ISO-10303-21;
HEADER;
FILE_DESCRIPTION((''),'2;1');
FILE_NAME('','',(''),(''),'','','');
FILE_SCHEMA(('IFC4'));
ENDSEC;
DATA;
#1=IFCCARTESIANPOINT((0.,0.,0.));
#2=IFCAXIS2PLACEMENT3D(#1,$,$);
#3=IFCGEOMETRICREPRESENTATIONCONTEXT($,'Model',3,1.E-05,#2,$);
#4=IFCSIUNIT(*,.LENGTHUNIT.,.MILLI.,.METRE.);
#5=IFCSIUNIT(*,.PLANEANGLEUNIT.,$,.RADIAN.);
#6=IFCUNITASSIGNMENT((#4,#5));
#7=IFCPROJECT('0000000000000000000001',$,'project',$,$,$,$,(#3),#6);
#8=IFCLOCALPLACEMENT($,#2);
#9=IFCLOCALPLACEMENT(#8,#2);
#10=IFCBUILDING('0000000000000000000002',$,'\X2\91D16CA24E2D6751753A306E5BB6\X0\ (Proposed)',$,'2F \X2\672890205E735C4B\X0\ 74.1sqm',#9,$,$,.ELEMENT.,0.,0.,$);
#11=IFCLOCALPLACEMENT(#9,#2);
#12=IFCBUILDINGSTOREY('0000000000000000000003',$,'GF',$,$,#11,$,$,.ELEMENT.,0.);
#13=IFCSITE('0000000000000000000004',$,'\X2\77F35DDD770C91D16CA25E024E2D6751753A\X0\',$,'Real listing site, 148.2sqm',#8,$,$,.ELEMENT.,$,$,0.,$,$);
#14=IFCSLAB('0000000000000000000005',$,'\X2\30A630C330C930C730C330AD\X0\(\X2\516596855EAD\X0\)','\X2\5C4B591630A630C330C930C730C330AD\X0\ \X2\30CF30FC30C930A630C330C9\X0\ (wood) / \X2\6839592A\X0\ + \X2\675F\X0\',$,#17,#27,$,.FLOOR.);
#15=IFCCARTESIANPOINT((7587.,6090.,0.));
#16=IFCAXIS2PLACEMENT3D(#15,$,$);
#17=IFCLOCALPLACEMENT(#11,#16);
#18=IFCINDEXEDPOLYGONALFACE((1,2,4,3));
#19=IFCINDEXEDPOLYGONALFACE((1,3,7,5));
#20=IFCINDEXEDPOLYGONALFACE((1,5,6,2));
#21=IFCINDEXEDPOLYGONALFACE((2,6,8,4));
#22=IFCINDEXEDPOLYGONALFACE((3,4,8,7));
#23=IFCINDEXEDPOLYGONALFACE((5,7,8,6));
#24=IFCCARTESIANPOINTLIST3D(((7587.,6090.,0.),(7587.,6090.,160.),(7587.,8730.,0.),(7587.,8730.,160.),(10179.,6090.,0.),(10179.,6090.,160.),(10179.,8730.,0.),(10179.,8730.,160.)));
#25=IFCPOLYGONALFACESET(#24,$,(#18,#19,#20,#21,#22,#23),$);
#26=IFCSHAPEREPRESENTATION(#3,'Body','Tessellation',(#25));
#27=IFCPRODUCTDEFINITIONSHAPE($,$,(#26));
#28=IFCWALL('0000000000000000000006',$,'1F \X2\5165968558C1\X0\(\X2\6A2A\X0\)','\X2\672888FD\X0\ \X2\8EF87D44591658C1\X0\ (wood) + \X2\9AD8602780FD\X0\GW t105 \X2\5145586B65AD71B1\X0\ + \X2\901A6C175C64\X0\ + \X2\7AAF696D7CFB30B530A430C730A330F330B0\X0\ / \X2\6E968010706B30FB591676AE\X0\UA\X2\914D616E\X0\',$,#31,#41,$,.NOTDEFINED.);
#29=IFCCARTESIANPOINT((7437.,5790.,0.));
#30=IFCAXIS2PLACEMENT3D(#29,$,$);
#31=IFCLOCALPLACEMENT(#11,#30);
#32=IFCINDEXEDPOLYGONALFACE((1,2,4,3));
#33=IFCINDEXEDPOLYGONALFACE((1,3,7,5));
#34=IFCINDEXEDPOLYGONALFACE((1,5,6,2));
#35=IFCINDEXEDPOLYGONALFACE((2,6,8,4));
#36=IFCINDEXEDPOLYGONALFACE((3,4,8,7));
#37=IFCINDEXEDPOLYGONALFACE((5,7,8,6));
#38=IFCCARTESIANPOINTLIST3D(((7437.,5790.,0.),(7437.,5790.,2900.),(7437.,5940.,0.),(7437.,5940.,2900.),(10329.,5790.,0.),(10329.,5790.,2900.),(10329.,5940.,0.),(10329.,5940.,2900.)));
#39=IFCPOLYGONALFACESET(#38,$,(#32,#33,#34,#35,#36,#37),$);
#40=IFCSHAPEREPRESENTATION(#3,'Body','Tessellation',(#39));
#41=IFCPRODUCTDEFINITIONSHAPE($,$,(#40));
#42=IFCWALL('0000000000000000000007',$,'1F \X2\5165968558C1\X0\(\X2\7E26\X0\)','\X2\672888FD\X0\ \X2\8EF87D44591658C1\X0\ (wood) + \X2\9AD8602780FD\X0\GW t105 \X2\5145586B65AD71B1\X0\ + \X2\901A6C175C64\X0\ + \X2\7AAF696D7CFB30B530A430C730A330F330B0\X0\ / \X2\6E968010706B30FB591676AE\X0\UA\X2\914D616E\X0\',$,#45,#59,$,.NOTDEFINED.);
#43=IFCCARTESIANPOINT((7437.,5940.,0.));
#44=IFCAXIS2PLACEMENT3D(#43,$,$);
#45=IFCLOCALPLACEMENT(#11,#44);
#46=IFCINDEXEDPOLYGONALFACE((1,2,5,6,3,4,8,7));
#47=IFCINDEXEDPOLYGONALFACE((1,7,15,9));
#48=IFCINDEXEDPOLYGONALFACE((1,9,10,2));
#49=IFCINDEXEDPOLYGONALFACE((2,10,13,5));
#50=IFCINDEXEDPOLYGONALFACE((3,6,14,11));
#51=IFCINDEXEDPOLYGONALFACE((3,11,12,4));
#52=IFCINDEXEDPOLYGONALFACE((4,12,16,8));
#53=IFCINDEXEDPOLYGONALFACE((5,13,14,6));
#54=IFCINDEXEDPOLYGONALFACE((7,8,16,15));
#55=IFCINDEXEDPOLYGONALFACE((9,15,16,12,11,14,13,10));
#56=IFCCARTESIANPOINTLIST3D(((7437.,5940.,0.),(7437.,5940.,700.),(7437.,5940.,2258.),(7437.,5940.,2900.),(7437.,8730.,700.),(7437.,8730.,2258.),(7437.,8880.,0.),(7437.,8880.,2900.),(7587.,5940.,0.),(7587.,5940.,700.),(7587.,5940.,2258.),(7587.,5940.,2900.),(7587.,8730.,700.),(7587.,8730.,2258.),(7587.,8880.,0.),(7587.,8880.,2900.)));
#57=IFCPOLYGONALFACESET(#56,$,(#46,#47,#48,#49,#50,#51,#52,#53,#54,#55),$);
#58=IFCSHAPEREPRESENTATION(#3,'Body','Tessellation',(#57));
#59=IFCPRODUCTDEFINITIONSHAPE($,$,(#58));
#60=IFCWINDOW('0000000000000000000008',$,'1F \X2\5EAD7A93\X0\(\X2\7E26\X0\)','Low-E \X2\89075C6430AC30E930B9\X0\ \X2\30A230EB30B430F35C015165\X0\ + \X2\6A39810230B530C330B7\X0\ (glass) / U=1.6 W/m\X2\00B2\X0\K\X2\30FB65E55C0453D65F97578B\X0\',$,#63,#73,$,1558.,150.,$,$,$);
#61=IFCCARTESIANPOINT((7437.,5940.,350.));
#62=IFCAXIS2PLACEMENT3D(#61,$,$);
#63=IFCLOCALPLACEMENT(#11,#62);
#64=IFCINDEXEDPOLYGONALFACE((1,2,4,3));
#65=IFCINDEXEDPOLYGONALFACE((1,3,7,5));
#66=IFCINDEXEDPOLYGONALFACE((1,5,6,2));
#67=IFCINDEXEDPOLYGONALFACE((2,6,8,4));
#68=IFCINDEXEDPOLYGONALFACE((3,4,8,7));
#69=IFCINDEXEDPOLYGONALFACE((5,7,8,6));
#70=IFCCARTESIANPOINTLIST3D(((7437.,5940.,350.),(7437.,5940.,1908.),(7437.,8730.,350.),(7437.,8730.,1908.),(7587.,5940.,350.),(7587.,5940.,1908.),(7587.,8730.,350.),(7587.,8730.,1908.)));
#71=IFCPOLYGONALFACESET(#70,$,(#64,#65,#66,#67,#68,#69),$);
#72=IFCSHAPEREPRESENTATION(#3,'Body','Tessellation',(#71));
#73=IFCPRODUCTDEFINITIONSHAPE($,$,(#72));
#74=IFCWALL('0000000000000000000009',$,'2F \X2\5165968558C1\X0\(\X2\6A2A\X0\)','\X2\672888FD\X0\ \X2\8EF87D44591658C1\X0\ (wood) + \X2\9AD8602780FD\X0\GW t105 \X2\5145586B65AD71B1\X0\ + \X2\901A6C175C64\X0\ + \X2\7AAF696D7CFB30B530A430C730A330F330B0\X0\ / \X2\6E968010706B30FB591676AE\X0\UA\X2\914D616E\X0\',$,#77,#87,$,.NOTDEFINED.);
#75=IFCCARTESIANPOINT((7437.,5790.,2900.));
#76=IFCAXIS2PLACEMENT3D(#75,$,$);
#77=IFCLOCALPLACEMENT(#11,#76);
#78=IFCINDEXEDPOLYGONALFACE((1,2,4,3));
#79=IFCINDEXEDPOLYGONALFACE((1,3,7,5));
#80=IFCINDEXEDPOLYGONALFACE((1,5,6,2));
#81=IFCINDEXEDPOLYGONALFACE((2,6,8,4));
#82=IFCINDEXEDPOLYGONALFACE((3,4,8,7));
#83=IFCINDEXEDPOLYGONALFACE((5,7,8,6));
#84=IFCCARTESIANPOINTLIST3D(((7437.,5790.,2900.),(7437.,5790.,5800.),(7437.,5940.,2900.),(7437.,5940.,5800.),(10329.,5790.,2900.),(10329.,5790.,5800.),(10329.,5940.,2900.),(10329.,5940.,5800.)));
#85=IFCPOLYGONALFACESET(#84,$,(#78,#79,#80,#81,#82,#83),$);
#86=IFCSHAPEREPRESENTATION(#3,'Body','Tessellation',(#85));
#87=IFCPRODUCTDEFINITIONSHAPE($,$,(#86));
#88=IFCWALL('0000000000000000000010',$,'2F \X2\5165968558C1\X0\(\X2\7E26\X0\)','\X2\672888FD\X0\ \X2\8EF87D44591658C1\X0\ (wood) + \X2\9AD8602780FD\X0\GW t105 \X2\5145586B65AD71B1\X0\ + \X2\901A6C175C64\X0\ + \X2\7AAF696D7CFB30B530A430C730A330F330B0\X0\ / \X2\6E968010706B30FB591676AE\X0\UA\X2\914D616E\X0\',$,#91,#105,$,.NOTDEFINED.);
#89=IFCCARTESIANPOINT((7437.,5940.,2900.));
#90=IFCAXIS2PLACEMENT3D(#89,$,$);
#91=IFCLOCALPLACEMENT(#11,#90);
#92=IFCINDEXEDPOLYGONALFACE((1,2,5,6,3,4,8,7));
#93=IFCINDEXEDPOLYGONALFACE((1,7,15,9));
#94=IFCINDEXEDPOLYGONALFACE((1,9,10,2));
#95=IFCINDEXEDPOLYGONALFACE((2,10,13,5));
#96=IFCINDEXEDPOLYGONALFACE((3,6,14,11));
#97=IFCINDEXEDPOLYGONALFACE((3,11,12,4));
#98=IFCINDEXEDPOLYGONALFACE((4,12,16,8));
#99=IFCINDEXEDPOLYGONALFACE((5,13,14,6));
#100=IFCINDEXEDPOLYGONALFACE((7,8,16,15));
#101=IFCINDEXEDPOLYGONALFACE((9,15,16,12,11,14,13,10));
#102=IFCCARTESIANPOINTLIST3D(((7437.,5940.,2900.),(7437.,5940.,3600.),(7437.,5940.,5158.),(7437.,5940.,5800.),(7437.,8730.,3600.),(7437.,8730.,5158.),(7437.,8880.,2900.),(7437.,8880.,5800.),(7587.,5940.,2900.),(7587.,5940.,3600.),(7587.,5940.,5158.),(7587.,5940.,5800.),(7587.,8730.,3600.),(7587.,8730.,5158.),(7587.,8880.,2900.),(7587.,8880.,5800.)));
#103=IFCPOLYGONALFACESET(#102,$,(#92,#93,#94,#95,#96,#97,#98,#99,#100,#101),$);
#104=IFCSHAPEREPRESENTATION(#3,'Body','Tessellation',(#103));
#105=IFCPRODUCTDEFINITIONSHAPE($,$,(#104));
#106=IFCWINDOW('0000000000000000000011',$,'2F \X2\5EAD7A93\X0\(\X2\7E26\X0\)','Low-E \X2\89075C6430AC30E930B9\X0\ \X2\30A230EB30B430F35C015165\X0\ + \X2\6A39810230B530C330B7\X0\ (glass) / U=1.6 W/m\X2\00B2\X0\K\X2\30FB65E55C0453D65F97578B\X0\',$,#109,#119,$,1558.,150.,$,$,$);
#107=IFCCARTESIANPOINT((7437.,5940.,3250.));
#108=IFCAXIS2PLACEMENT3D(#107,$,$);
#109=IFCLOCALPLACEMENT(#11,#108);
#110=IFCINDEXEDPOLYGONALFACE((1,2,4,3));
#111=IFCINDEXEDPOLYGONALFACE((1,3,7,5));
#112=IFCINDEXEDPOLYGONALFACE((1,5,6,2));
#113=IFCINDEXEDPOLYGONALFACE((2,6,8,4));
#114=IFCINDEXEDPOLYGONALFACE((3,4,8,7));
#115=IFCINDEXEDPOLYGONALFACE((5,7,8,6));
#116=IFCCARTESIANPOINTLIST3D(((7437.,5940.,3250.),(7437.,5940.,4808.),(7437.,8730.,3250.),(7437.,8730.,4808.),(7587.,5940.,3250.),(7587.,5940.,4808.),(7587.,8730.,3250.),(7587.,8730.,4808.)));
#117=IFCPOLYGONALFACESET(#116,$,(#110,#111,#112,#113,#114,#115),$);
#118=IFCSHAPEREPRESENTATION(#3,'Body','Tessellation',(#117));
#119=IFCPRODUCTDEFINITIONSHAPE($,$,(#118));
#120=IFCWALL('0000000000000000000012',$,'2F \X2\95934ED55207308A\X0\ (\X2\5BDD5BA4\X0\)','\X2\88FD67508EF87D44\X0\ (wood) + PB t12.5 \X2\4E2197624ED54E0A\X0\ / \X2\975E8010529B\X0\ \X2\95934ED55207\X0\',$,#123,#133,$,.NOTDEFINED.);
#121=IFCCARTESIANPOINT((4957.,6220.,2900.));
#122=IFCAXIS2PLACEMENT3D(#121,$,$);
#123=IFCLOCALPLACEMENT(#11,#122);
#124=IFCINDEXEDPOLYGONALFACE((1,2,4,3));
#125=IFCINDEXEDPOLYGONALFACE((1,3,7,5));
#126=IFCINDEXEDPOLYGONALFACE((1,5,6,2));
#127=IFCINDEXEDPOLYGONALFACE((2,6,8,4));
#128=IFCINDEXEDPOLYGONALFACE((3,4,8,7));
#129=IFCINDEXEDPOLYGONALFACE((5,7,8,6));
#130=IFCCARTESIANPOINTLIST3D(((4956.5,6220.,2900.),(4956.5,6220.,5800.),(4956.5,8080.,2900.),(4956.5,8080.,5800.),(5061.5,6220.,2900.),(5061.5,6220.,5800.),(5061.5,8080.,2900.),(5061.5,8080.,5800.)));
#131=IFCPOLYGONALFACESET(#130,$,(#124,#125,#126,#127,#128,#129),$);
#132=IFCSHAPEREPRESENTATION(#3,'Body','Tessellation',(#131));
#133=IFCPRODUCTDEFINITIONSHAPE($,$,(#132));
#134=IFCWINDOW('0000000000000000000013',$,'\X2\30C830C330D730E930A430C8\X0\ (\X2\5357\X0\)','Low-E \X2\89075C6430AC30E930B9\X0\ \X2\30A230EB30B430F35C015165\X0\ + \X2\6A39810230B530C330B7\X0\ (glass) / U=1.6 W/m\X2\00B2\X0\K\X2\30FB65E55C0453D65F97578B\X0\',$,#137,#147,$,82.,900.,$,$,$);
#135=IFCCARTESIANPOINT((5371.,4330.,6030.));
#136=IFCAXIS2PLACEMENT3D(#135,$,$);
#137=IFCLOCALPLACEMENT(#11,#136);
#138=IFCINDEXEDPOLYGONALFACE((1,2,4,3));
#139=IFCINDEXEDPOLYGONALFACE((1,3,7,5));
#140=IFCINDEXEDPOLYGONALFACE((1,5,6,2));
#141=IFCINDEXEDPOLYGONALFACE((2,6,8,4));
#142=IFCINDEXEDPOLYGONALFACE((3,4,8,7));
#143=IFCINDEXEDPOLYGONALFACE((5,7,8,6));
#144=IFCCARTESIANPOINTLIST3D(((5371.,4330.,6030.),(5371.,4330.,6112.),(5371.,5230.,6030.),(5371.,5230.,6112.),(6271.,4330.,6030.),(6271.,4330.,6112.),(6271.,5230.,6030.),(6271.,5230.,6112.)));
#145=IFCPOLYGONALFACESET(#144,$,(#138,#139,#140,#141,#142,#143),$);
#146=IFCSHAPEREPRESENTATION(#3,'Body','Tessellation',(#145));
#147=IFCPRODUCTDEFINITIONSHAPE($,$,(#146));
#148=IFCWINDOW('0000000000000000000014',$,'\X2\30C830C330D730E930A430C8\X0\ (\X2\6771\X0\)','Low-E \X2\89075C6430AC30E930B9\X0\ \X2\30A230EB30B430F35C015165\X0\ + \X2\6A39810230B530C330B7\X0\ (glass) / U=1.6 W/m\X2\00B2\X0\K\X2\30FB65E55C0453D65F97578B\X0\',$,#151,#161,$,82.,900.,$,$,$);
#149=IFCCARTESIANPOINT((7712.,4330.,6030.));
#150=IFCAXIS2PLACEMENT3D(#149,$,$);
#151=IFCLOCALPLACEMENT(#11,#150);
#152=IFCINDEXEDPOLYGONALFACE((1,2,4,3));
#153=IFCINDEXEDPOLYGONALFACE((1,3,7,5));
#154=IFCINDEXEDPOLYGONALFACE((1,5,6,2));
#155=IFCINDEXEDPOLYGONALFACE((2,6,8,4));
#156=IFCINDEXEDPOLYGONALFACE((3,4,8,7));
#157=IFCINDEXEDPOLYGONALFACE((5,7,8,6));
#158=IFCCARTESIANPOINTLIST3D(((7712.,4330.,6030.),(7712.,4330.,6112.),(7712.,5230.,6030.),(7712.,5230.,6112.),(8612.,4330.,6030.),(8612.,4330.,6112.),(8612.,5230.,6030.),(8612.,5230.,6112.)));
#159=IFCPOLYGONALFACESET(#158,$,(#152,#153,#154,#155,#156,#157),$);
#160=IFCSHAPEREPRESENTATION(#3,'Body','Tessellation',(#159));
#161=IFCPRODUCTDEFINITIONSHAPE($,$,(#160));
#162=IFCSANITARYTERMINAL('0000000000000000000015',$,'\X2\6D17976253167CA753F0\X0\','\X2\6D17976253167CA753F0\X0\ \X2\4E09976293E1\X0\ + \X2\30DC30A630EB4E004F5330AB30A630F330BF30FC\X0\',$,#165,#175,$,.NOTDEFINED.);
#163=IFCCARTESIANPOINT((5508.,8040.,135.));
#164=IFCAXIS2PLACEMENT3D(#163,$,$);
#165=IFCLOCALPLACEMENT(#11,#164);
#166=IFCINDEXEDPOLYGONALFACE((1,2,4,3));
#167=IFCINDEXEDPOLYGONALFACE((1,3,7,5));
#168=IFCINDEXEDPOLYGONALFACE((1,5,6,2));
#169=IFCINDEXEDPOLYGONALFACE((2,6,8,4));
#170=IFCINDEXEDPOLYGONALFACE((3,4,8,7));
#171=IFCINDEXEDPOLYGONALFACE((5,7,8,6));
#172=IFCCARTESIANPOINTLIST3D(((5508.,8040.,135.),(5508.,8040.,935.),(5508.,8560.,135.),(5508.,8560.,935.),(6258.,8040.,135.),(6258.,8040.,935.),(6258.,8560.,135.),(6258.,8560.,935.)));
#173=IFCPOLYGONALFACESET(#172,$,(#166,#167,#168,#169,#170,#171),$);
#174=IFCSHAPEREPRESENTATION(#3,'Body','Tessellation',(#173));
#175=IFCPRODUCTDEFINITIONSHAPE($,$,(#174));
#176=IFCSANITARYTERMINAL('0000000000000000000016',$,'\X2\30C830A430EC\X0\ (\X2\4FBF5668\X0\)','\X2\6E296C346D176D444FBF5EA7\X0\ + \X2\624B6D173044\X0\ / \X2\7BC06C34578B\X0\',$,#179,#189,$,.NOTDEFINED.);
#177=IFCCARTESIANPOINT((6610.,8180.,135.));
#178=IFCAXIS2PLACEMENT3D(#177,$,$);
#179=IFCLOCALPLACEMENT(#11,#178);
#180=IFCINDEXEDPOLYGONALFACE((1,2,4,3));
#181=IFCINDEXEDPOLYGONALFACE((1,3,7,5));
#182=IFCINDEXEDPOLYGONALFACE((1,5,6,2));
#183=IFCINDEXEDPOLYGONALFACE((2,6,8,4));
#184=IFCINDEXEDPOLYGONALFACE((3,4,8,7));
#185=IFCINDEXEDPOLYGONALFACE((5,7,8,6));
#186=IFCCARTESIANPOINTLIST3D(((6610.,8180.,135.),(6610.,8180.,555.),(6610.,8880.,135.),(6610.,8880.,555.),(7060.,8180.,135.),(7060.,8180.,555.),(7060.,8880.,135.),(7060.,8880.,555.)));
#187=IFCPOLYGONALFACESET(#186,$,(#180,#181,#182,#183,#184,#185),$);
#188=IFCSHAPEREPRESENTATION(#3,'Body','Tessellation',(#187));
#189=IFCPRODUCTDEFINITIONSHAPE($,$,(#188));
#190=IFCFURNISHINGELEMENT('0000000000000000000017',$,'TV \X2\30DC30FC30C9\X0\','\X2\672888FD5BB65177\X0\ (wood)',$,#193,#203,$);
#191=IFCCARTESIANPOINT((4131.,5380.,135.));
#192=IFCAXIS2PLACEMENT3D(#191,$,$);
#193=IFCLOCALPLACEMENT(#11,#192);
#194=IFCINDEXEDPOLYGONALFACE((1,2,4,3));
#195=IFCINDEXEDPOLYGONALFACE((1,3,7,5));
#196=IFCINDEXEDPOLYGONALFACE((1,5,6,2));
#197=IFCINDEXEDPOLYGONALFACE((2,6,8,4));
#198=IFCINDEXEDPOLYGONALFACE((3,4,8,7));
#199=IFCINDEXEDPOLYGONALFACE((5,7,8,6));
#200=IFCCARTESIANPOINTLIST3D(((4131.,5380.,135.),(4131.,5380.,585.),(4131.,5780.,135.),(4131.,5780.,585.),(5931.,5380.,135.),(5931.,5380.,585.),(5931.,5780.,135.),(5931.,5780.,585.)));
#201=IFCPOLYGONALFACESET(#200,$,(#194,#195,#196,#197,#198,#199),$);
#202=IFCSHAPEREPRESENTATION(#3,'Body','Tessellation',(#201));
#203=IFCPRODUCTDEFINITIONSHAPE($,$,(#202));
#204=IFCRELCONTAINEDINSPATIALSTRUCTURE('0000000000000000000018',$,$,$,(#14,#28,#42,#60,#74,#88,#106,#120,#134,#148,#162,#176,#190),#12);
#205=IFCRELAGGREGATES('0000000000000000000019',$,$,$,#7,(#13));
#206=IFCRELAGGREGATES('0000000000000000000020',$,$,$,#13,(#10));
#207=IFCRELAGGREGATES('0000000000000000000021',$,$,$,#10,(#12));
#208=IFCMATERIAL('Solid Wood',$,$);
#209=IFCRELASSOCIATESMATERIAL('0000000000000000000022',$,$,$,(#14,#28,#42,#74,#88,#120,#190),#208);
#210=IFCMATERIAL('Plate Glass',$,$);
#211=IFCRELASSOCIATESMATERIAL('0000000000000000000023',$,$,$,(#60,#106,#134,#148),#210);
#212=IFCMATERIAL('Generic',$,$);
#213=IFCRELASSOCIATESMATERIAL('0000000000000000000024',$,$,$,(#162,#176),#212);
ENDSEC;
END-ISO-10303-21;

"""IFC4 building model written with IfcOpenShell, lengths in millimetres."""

from ifc_helpers import new_model, si_unit, frame, frame_2d, origin, place, context, project, spatial, rectangle, extrude, material, element, fill, save


model = new_model("IFC4")

# Units and contexts
model_context = context("Model", 3, precision=1e-05, world=origin())
ifc_project = project(units=[si_unit("LENGTHUNIT", "METRE", prefix="MILLI"), si_unit("PLANEANGLEUNIT", "RADIAN")], contexts=[model_context])

# Site, building, storey
site_placement = place(None, origin())
site = spatial("IfcSite", under=ifc_project, at=site_placement, Name="石川県金沢市中村町", ObjectType="Real listing site, 148.2sqm", CompositionType="ELEMENT", RefElevation=0.0)
building_placement = place(site_placement, origin())
building = spatial("IfcBuilding", under=site, at=building_placement, Name="金沢中村町の家 (Proposed)", ObjectType="2F 木造平屋 74.1sqm", CompositionType="ELEMENT", ElevationOfRefHeight=0.0, ElevationOfTerrain=0.0)
storey_placement = place(building_placement, origin())
storey = spatial("IfcBuildingStorey", under=building, at=storey_placement, Name="GF", CompositionType="ELEMENT", Elevation=0.0)

# Slab
ifc_material_1 = material(Name="Solid Wood")
slab_placement = place(storey_placement, frame((7587.0, 6090.0, 0.0)))
element("IfcSlab", 1, at=slab_placement, inside=storey, material=ifc_material_1, Name="ウッドデッキ(入隅庭)", Description="屋外ウッドデッキ ハードウッド (wood) / 根太 + 束", PredefinedType="FLOOR", context=model_context, shape_type="SweptSolid", body=[
    extrude(rectangle(XDim=2592.0, YDim=2640.0, at=frame_2d((1296.0, 1320.0))), frame((7587.0, 6090.0, 0.0)), (0.0, 0.0, 1.0), 160.0),
])

# Wall
wall_1_placement = place(storey_placement, frame((7437.0, 5790.0, 0.0)))
element("IfcWall", 2, at=wall_1_placement, inside=storey, material=ifc_material_1, Name="1F 入隅壁(横)", Description="木製 軸組外壁 (wood) + 高性能GW t105 充填断熱 + 通気層 + 窯業系サイディング / 準耐火・外皮UA配慮", PredefinedType="NOTDEFINED", context=model_context, shape_type="SweptSolid", body=[
    extrude(rectangle(XDim=2892.0, YDim=150.0, at=frame_2d((1446.0, 75.0))), frame((7437.0, 5790.0, 0.0)), (0.0, 0.0, 1.0), 2900.0),
])

# Wall, opening, window
wall_2_placement = place(storey_placement, frame((7437.0, 5940.0, 0.0)))
wall_2 = element("IfcWall", 3, at=wall_2_placement, inside=storey, material=ifc_material_1, Name="1F 入隅壁(縦)", Description="木製 軸組外壁 (wood) + 高性能GW t105 充填断熱 + 通気層 + 窯業系サイディング / 準耐火・外皮UA配慮", PredefinedType="NOTDEFINED", context=model_context, shape_type="SweptSolid", body=[
    extrude(rectangle(XDim=150.0, YDim=2940.0, at=frame_2d((75.0, 1470.0))), frame((7437.0, 5940.0, 0.0)), (0.0, 0.0, 1.0), 2900.0),
])
opening_1_placement = place(storey_placement, frame((7437.0, 5940.0, 350.0)))
opening_1 = element("IfcOpeningElement", 4, at=opening_1_placement, cuts=wall_2, PredefinedType="NOTDEFINED", context=model_context, shape_type="SweptSolid", body=[
    extrude(rectangle(XDim=150.0, YDim=2790.0, at=frame_2d((75.0, 1395.0))), frame((7437.0, 5940.0, 350.0)), (0.0, 0.0, 1.0), 1558.0),
])
ifc_material_2 = material(Name="Plate Glass")
window_1_placement = place(storey_placement, frame((7437.0, 5940.0, 350.0)))
window_1 = element("IfcWindow", 5, at=window_1_placement, inside=storey, material=ifc_material_2, Name="1F 庭窓(縦)", Description="Low-E 複層ガラス アルゴン封入 + 樹脂サッシ (glass) / U=1.6 W/m²K・日射取得型", OverallHeight=1558.0, OverallWidth=150.0, context=model_context, shape_type="SweptSolid", body=[
    extrude(rectangle(XDim=150.0, YDim=2790.0, at=frame_2d((75.0, 1395.0))), frame((7437.0, 5940.0, 350.0)), (0.0, 0.0, 1.0), 1558.0),
])
fill(opening_1, window_1)

# Wall
wall_3_placement = place(storey_placement, frame((7437.0, 5790.0, 2900.0)))
element("IfcWall", 6, at=wall_3_placement, inside=storey, material=ifc_material_1, Name="2F 入隅壁(横)", Description="木製 軸組外壁 (wood) + 高性能GW t105 充填断熱 + 通気層 + 窯業系サイディング / 準耐火・外皮UA配慮", PredefinedType="NOTDEFINED", context=model_context, shape_type="SweptSolid", body=[
    extrude(rectangle(XDim=2892.0, YDim=150.0, at=frame_2d((1446.0, 75.0))), frame((7437.0, 5790.0, 2900.0)), (0.0, 0.0, 1.0), 2900.0),
])

# Wall, opening, window
wall_4_placement = place(storey_placement, frame((7437.0, 5940.0, 2900.0)))
wall_4 = element("IfcWall", 7, at=wall_4_placement, inside=storey, material=ifc_material_1, Name="2F 入隅壁(縦)", Description="木製 軸組外壁 (wood) + 高性能GW t105 充填断熱 + 通気層 + 窯業系サイディング / 準耐火・外皮UA配慮", PredefinedType="NOTDEFINED", context=model_context, shape_type="SweptSolid", body=[
    extrude(rectangle(XDim=150.0, YDim=2940.0, at=frame_2d((75.0, 1470.0))), frame((7437.0, 5940.0, 2900.0)), (0.0, 0.0, 1.0), 2900.0),
])
opening_2_placement = place(storey_placement, frame((7437.0, 5940.0, 3250.0)))
opening_2 = element("IfcOpeningElement", 8, at=opening_2_placement, cuts=wall_4, PredefinedType="NOTDEFINED", context=model_context, shape_type="SweptSolid", body=[
    extrude(rectangle(XDim=150.0, YDim=2790.0, at=frame_2d((75.0, 1395.0))), frame((7437.0, 5940.0, 3250.0)), (0.0, 0.0, 1.0), 1558.0),
])
window_2_placement = place(storey_placement, frame((7437.0, 5940.0, 3250.0)))
window_2 = element("IfcWindow", 9, at=window_2_placement, inside=storey, material=ifc_material_2, Name="2F 庭窓(縦)", Description="Low-E 複層ガラス アルゴン封入 + 樹脂サッシ (glass) / U=1.6 W/m²K・日射取得型", OverallHeight=1558.0, OverallWidth=150.0, context=model_context, shape_type="SweptSolid", body=[
    extrude(rectangle(XDim=150.0, YDim=2790.0, at=frame_2d((75.0, 1395.0))), frame((7437.0, 5940.0, 3250.0)), (0.0, 0.0, 1.0), 1558.0),
])
fill(opening_2, window_2)

# Wall
wall_5_placement = place(storey_placement, frame((4957.0, 6220.0, 2900.0)))
element("IfcWall", 10, at=wall_5_placement, inside=storey, material=ifc_material_1, Name="2F 間仕切り (寝室)", Description="製材軸組 (wood) + PB t12.5 両面仕上 / 非耐力 間仕切", PredefinedType="NOTDEFINED", context=model_context, shape_type="SweptSolid", body=[
    extrude(rectangle(XDim=105.0, YDim=1860.0, at=frame_2d((52.0, 930.0))), frame((4957.0, 6220.0, 2900.0)), (0.0, 0.0, 1.0), 2900.0),
])

# Windows
window_3_placement = place(storey_placement, frame((5371.0, 4330.0, 6030.0)))
element("IfcWindow", 11, at=window_3_placement, inside=storey, material=ifc_material_2, Name="トップライト (南)", Description="Low-E 複層ガラス アルゴン封入 + 樹脂サッシ (glass) / U=1.6 W/m²K・日射取得型", OverallHeight=82.0, OverallWidth=900.0, context=model_context, shape_type="SweptSolid", body=[
    extrude(rectangle(XDim=900.0, YDim=900.0, at=frame_2d((450.0, 450.0))), frame((5371.0, 4330.0, 6030.0)), (0.0, 0.0, 1.0), 82.0),
])
window_4_placement = place(storey_placement, frame((7712.0, 4330.0, 6030.0)))
element("IfcWindow", 12, at=window_4_placement, inside=storey, material=ifc_material_2, Name="トップライト (東)", Description="Low-E 複層ガラス アルゴン封入 + 樹脂サッシ (glass) / U=1.6 W/m²K・日射取得型", OverallHeight=82.0, OverallWidth=900.0, context=model_context, shape_type="SweptSolid", body=[
    extrude(rectangle(XDim=900.0, YDim=900.0, at=frame_2d((450.0, 450.0))), frame((7712.0, 4330.0, 6030.0)), (0.0, 0.0, 1.0), 82.0),
])

# Sanitary terminals
ifc_material_3 = material(Name="Generic")
sanitary_terminal_1_placement = place(storey_placement, frame((5508.0, 8040.0, 135.0)))
element("IfcSanitaryTerminal", 13, at=sanitary_terminal_1_placement, inside=storey, material=ifc_material_3, Name="洗面化粧台", Description="洗面化粧台 三面鏡 + ボウル一体カウンター", PredefinedType="NOTDEFINED", context=model_context, shape_type="SweptSolid", body=[
    extrude(rectangle(XDim=750.0, YDim=520.0, at=frame_2d((375.0, 260.0))), frame((5508.0, 8040.0, 135.0)), (0.0, 0.0, 1.0), 800.0),
])
sanitary_terminal_2_placement = place(storey_placement, frame((6610.0, 8180.0, 135.0)))
element("IfcSanitaryTerminal", 14, at=sanitary_terminal_2_placement, inside=storey, material=ifc_material_3, Name="トイレ (便器)", Description="温水洗浄便座 + 手洗い / 節水型", PredefinedType="NOTDEFINED", context=model_context, shape_type="SweptSolid", body=[
    extrude(rectangle(XDim=450.0, YDim=700.0, at=frame_2d((225.0, 350.0))), frame((6610.0, 8180.0, 135.0)), (0.0, 0.0, 1.0), 420.0),
])

# Furnishing element
furnishing_1_placement = place(storey_placement, frame((4131.0, 5380.0, 135.0)))
element("IfcFurnishingElement", 15, at=furnishing_1_placement, inside=storey, material=ifc_material_1, Name="TV ボード", Description="木製家具 (wood)", context=model_context, shape_type="SweptSolid", body=[
    extrude(rectangle(XDim=1800.0, YDim=400.0, at=frame_2d((900.0, 200.0))), frame((4131.0, 5380.0, 135.0)), (0.0, 0.0, 1.0), 450.0),
])

save(model, "model.ifc")
